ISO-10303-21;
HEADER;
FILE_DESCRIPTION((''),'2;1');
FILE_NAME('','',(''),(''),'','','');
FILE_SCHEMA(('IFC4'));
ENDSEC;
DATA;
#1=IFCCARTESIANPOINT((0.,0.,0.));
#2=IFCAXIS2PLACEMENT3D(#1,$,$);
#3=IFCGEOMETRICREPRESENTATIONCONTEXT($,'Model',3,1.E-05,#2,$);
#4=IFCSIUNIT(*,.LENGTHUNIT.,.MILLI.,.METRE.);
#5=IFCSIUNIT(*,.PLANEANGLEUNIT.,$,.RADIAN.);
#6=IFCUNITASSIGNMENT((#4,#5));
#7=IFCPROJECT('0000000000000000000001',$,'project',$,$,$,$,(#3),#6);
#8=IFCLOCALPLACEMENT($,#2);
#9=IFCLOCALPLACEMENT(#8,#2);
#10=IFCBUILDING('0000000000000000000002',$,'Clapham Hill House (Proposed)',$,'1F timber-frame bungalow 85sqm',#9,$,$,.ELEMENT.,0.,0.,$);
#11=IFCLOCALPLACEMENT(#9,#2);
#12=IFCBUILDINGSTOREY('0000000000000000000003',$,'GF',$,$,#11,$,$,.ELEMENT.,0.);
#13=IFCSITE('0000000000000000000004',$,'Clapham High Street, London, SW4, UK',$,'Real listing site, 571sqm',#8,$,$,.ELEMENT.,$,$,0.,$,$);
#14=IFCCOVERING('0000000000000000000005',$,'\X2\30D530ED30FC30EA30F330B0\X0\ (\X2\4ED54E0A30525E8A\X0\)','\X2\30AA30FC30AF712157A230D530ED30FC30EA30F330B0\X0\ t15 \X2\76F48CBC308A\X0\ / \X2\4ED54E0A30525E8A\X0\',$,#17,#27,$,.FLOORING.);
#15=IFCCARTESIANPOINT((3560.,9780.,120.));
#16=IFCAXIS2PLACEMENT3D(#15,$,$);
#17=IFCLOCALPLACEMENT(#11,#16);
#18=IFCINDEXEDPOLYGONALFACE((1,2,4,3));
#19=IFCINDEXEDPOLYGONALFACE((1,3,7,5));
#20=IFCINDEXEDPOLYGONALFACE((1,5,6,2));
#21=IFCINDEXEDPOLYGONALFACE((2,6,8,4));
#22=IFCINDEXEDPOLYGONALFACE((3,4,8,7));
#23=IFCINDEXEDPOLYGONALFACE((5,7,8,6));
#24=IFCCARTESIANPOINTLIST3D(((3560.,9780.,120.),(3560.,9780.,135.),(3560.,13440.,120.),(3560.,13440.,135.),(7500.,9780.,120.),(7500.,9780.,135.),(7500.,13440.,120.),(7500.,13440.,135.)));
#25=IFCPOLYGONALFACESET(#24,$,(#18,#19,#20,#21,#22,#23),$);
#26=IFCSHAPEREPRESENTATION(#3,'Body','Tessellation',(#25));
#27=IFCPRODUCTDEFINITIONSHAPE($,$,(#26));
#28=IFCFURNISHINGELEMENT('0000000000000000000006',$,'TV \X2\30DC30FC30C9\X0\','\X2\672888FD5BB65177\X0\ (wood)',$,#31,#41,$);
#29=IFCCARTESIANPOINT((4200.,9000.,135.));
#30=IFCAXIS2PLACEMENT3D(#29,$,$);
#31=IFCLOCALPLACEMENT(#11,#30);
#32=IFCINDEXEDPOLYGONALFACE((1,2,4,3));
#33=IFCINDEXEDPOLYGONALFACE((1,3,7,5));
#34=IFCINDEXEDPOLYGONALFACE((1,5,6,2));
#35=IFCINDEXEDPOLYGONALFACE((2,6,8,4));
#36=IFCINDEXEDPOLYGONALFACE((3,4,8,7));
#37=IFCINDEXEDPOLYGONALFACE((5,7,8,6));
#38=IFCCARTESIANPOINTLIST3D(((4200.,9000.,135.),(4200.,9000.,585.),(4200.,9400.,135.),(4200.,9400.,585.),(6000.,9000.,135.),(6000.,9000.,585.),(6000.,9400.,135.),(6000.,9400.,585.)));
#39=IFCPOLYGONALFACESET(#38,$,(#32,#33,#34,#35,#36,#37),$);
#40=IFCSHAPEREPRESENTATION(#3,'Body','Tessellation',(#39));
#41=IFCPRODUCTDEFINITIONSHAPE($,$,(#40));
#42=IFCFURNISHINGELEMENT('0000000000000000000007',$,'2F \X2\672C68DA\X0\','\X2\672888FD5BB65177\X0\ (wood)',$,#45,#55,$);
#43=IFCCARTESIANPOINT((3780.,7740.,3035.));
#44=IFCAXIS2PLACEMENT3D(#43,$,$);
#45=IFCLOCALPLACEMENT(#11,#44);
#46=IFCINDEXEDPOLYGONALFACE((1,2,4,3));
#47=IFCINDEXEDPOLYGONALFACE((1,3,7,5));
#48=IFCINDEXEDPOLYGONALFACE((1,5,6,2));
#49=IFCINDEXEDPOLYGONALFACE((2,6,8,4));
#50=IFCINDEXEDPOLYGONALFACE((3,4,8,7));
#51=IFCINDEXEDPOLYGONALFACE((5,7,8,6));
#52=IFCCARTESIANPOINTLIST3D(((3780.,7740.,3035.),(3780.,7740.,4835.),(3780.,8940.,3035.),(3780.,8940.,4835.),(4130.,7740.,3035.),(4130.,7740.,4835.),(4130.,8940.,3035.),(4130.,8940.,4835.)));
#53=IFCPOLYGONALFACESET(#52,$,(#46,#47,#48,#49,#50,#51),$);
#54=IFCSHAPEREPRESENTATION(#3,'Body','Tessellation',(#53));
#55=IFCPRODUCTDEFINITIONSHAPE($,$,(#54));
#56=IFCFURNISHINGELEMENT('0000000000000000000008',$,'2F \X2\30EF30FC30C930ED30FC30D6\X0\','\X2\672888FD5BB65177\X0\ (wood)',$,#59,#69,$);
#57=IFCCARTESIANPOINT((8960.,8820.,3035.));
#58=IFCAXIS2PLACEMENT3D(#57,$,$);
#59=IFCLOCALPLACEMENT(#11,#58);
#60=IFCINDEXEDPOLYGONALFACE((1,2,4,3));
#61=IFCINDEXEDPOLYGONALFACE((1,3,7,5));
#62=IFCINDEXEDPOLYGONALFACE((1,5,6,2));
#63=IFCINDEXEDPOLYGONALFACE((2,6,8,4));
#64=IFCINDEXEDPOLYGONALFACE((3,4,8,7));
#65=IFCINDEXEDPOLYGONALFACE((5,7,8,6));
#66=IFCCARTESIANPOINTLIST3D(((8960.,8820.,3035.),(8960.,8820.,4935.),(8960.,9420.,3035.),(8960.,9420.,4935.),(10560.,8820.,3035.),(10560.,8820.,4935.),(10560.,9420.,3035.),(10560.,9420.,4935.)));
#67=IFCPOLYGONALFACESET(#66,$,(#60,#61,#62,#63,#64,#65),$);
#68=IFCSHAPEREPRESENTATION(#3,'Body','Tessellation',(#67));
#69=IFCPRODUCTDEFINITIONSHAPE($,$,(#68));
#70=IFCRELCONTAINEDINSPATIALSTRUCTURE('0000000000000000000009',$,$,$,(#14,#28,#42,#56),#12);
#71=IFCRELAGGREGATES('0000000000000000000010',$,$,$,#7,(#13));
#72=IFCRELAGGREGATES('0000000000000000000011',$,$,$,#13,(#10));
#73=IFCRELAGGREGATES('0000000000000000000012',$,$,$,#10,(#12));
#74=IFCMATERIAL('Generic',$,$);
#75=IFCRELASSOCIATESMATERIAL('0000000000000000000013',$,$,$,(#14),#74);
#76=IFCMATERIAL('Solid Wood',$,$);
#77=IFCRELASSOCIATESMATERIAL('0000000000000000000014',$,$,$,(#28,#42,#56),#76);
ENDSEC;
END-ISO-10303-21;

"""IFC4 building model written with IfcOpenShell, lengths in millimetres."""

from ifc_helpers import new_model, si_unit, frame, frame_2d, origin, place, context, project, spatial, rectangle, extrude, material, element, save


model = new_model("IFC4")

# Units and contexts
model_context = context("Model", 3, precision=1e-05, world=origin())
ifc_project = project(units=[si_unit("LENGTHUNIT", "METRE", prefix="MILLI"), si_unit("PLANEANGLEUNIT", "RADIAN")], contexts=[model_context])

# Site, building, storey
site_placement = place(None, origin())
site = spatial("IfcSite", under=ifc_project, at=site_placement, Name="Clapham High Street, London, SW4, UK", ObjectType="Real listing site, 571sqm", CompositionType="ELEMENT", RefElevation=0.0)
building_placement = place(site_placement, origin())
building = spatial("IfcBuilding", under=site, at=building_placement, Name="Clapham Hill House (Proposed)", ObjectType="1F timber-frame bungalow 85sqm", CompositionType="ELEMENT", ElevationOfRefHeight=0.0, ElevationOfTerrain=0.0)
storey_placement = place(building_placement, origin())
storey = spatial("IfcBuildingStorey", under=building, at=storey_placement, Name="GF", CompositionType="ELEMENT", Elevation=0.0)

# Shared definitions
ifc_material_1 = material(Name="Solid Wood")

# Shared definitions
ifc_material_2 = material(Name="Generic")

# Covering
covering_placement = place(storey_placement, frame((3560.0, 9780.0, 120.0)))
element("IfcCovering", 1, at=covering_placement, inside=storey, material=ifc_material_2, Name="フローリング (仕上げ床)", Description="オーク無垢フローリング t15 直貼り / 仕上げ床", PredefinedType="FLOORING", context=model_context, shape_type="SweptSolid", body=[
    extrude(rectangle(XDim=3940.0, YDim=3660.0, at=frame_2d((1970.0, 1830.0))), frame((3560.0, 9780.0, 120.0)), (0.0, 0.0, 1.0), 15.0),
])

# Furnishing elements
furnishing_1_placement = place(storey_placement, frame((4200.0, 9000.0, 135.0)))
element("IfcFurnishingElement", 2, at=furnishing_1_placement, inside=storey, material=ifc_material_1, Name="TV ボード", Description="木製家具 (wood)", context=model_context, shape_type="SweptSolid", body=[
    extrude(rectangle(XDim=1800.0, YDim=400.0, at=frame_2d((900.0, 200.0))), frame((4200.0, 9000.0, 135.0)), (0.0, 0.0, 1.0), 450.0),
])
furnishing_2_placement = place(storey_placement, frame((3780.0, 7740.0, 3035.0)))
element("IfcFurnishingElement", 3, at=furnishing_2_placement, inside=storey, material=ifc_material_1, Name="2F 本棚", Description="木製家具 (wood)", context=model_context, shape_type="SweptSolid", body=[
    extrude(rectangle(XDim=350.0, YDim=1200.0, at=frame_2d((175.0, 600.0))), frame((3780.0, 7740.0, 3035.0)), (0.0, 0.0, 1.0), 1800.0),
])
furnishing_3_placement = place(storey_placement, frame((8960.0, 8820.0, 3035.0)))
element("IfcFurnishingElement", 4, at=furnishing_3_placement, inside=storey, material=ifc_material_1, Name="2F ワードローブ", Description="木製家具 (wood)", context=model_context, shape_type="SweptSolid", body=[
    extrude(rectangle(XDim=1600.0, YDim=600.0, at=frame_2d((800.0, 300.0))), frame((8960.0, 8820.0, 3035.0)), (0.0, 0.0, 1.0), 1900.0),
])

save(model, "model.ifc")
